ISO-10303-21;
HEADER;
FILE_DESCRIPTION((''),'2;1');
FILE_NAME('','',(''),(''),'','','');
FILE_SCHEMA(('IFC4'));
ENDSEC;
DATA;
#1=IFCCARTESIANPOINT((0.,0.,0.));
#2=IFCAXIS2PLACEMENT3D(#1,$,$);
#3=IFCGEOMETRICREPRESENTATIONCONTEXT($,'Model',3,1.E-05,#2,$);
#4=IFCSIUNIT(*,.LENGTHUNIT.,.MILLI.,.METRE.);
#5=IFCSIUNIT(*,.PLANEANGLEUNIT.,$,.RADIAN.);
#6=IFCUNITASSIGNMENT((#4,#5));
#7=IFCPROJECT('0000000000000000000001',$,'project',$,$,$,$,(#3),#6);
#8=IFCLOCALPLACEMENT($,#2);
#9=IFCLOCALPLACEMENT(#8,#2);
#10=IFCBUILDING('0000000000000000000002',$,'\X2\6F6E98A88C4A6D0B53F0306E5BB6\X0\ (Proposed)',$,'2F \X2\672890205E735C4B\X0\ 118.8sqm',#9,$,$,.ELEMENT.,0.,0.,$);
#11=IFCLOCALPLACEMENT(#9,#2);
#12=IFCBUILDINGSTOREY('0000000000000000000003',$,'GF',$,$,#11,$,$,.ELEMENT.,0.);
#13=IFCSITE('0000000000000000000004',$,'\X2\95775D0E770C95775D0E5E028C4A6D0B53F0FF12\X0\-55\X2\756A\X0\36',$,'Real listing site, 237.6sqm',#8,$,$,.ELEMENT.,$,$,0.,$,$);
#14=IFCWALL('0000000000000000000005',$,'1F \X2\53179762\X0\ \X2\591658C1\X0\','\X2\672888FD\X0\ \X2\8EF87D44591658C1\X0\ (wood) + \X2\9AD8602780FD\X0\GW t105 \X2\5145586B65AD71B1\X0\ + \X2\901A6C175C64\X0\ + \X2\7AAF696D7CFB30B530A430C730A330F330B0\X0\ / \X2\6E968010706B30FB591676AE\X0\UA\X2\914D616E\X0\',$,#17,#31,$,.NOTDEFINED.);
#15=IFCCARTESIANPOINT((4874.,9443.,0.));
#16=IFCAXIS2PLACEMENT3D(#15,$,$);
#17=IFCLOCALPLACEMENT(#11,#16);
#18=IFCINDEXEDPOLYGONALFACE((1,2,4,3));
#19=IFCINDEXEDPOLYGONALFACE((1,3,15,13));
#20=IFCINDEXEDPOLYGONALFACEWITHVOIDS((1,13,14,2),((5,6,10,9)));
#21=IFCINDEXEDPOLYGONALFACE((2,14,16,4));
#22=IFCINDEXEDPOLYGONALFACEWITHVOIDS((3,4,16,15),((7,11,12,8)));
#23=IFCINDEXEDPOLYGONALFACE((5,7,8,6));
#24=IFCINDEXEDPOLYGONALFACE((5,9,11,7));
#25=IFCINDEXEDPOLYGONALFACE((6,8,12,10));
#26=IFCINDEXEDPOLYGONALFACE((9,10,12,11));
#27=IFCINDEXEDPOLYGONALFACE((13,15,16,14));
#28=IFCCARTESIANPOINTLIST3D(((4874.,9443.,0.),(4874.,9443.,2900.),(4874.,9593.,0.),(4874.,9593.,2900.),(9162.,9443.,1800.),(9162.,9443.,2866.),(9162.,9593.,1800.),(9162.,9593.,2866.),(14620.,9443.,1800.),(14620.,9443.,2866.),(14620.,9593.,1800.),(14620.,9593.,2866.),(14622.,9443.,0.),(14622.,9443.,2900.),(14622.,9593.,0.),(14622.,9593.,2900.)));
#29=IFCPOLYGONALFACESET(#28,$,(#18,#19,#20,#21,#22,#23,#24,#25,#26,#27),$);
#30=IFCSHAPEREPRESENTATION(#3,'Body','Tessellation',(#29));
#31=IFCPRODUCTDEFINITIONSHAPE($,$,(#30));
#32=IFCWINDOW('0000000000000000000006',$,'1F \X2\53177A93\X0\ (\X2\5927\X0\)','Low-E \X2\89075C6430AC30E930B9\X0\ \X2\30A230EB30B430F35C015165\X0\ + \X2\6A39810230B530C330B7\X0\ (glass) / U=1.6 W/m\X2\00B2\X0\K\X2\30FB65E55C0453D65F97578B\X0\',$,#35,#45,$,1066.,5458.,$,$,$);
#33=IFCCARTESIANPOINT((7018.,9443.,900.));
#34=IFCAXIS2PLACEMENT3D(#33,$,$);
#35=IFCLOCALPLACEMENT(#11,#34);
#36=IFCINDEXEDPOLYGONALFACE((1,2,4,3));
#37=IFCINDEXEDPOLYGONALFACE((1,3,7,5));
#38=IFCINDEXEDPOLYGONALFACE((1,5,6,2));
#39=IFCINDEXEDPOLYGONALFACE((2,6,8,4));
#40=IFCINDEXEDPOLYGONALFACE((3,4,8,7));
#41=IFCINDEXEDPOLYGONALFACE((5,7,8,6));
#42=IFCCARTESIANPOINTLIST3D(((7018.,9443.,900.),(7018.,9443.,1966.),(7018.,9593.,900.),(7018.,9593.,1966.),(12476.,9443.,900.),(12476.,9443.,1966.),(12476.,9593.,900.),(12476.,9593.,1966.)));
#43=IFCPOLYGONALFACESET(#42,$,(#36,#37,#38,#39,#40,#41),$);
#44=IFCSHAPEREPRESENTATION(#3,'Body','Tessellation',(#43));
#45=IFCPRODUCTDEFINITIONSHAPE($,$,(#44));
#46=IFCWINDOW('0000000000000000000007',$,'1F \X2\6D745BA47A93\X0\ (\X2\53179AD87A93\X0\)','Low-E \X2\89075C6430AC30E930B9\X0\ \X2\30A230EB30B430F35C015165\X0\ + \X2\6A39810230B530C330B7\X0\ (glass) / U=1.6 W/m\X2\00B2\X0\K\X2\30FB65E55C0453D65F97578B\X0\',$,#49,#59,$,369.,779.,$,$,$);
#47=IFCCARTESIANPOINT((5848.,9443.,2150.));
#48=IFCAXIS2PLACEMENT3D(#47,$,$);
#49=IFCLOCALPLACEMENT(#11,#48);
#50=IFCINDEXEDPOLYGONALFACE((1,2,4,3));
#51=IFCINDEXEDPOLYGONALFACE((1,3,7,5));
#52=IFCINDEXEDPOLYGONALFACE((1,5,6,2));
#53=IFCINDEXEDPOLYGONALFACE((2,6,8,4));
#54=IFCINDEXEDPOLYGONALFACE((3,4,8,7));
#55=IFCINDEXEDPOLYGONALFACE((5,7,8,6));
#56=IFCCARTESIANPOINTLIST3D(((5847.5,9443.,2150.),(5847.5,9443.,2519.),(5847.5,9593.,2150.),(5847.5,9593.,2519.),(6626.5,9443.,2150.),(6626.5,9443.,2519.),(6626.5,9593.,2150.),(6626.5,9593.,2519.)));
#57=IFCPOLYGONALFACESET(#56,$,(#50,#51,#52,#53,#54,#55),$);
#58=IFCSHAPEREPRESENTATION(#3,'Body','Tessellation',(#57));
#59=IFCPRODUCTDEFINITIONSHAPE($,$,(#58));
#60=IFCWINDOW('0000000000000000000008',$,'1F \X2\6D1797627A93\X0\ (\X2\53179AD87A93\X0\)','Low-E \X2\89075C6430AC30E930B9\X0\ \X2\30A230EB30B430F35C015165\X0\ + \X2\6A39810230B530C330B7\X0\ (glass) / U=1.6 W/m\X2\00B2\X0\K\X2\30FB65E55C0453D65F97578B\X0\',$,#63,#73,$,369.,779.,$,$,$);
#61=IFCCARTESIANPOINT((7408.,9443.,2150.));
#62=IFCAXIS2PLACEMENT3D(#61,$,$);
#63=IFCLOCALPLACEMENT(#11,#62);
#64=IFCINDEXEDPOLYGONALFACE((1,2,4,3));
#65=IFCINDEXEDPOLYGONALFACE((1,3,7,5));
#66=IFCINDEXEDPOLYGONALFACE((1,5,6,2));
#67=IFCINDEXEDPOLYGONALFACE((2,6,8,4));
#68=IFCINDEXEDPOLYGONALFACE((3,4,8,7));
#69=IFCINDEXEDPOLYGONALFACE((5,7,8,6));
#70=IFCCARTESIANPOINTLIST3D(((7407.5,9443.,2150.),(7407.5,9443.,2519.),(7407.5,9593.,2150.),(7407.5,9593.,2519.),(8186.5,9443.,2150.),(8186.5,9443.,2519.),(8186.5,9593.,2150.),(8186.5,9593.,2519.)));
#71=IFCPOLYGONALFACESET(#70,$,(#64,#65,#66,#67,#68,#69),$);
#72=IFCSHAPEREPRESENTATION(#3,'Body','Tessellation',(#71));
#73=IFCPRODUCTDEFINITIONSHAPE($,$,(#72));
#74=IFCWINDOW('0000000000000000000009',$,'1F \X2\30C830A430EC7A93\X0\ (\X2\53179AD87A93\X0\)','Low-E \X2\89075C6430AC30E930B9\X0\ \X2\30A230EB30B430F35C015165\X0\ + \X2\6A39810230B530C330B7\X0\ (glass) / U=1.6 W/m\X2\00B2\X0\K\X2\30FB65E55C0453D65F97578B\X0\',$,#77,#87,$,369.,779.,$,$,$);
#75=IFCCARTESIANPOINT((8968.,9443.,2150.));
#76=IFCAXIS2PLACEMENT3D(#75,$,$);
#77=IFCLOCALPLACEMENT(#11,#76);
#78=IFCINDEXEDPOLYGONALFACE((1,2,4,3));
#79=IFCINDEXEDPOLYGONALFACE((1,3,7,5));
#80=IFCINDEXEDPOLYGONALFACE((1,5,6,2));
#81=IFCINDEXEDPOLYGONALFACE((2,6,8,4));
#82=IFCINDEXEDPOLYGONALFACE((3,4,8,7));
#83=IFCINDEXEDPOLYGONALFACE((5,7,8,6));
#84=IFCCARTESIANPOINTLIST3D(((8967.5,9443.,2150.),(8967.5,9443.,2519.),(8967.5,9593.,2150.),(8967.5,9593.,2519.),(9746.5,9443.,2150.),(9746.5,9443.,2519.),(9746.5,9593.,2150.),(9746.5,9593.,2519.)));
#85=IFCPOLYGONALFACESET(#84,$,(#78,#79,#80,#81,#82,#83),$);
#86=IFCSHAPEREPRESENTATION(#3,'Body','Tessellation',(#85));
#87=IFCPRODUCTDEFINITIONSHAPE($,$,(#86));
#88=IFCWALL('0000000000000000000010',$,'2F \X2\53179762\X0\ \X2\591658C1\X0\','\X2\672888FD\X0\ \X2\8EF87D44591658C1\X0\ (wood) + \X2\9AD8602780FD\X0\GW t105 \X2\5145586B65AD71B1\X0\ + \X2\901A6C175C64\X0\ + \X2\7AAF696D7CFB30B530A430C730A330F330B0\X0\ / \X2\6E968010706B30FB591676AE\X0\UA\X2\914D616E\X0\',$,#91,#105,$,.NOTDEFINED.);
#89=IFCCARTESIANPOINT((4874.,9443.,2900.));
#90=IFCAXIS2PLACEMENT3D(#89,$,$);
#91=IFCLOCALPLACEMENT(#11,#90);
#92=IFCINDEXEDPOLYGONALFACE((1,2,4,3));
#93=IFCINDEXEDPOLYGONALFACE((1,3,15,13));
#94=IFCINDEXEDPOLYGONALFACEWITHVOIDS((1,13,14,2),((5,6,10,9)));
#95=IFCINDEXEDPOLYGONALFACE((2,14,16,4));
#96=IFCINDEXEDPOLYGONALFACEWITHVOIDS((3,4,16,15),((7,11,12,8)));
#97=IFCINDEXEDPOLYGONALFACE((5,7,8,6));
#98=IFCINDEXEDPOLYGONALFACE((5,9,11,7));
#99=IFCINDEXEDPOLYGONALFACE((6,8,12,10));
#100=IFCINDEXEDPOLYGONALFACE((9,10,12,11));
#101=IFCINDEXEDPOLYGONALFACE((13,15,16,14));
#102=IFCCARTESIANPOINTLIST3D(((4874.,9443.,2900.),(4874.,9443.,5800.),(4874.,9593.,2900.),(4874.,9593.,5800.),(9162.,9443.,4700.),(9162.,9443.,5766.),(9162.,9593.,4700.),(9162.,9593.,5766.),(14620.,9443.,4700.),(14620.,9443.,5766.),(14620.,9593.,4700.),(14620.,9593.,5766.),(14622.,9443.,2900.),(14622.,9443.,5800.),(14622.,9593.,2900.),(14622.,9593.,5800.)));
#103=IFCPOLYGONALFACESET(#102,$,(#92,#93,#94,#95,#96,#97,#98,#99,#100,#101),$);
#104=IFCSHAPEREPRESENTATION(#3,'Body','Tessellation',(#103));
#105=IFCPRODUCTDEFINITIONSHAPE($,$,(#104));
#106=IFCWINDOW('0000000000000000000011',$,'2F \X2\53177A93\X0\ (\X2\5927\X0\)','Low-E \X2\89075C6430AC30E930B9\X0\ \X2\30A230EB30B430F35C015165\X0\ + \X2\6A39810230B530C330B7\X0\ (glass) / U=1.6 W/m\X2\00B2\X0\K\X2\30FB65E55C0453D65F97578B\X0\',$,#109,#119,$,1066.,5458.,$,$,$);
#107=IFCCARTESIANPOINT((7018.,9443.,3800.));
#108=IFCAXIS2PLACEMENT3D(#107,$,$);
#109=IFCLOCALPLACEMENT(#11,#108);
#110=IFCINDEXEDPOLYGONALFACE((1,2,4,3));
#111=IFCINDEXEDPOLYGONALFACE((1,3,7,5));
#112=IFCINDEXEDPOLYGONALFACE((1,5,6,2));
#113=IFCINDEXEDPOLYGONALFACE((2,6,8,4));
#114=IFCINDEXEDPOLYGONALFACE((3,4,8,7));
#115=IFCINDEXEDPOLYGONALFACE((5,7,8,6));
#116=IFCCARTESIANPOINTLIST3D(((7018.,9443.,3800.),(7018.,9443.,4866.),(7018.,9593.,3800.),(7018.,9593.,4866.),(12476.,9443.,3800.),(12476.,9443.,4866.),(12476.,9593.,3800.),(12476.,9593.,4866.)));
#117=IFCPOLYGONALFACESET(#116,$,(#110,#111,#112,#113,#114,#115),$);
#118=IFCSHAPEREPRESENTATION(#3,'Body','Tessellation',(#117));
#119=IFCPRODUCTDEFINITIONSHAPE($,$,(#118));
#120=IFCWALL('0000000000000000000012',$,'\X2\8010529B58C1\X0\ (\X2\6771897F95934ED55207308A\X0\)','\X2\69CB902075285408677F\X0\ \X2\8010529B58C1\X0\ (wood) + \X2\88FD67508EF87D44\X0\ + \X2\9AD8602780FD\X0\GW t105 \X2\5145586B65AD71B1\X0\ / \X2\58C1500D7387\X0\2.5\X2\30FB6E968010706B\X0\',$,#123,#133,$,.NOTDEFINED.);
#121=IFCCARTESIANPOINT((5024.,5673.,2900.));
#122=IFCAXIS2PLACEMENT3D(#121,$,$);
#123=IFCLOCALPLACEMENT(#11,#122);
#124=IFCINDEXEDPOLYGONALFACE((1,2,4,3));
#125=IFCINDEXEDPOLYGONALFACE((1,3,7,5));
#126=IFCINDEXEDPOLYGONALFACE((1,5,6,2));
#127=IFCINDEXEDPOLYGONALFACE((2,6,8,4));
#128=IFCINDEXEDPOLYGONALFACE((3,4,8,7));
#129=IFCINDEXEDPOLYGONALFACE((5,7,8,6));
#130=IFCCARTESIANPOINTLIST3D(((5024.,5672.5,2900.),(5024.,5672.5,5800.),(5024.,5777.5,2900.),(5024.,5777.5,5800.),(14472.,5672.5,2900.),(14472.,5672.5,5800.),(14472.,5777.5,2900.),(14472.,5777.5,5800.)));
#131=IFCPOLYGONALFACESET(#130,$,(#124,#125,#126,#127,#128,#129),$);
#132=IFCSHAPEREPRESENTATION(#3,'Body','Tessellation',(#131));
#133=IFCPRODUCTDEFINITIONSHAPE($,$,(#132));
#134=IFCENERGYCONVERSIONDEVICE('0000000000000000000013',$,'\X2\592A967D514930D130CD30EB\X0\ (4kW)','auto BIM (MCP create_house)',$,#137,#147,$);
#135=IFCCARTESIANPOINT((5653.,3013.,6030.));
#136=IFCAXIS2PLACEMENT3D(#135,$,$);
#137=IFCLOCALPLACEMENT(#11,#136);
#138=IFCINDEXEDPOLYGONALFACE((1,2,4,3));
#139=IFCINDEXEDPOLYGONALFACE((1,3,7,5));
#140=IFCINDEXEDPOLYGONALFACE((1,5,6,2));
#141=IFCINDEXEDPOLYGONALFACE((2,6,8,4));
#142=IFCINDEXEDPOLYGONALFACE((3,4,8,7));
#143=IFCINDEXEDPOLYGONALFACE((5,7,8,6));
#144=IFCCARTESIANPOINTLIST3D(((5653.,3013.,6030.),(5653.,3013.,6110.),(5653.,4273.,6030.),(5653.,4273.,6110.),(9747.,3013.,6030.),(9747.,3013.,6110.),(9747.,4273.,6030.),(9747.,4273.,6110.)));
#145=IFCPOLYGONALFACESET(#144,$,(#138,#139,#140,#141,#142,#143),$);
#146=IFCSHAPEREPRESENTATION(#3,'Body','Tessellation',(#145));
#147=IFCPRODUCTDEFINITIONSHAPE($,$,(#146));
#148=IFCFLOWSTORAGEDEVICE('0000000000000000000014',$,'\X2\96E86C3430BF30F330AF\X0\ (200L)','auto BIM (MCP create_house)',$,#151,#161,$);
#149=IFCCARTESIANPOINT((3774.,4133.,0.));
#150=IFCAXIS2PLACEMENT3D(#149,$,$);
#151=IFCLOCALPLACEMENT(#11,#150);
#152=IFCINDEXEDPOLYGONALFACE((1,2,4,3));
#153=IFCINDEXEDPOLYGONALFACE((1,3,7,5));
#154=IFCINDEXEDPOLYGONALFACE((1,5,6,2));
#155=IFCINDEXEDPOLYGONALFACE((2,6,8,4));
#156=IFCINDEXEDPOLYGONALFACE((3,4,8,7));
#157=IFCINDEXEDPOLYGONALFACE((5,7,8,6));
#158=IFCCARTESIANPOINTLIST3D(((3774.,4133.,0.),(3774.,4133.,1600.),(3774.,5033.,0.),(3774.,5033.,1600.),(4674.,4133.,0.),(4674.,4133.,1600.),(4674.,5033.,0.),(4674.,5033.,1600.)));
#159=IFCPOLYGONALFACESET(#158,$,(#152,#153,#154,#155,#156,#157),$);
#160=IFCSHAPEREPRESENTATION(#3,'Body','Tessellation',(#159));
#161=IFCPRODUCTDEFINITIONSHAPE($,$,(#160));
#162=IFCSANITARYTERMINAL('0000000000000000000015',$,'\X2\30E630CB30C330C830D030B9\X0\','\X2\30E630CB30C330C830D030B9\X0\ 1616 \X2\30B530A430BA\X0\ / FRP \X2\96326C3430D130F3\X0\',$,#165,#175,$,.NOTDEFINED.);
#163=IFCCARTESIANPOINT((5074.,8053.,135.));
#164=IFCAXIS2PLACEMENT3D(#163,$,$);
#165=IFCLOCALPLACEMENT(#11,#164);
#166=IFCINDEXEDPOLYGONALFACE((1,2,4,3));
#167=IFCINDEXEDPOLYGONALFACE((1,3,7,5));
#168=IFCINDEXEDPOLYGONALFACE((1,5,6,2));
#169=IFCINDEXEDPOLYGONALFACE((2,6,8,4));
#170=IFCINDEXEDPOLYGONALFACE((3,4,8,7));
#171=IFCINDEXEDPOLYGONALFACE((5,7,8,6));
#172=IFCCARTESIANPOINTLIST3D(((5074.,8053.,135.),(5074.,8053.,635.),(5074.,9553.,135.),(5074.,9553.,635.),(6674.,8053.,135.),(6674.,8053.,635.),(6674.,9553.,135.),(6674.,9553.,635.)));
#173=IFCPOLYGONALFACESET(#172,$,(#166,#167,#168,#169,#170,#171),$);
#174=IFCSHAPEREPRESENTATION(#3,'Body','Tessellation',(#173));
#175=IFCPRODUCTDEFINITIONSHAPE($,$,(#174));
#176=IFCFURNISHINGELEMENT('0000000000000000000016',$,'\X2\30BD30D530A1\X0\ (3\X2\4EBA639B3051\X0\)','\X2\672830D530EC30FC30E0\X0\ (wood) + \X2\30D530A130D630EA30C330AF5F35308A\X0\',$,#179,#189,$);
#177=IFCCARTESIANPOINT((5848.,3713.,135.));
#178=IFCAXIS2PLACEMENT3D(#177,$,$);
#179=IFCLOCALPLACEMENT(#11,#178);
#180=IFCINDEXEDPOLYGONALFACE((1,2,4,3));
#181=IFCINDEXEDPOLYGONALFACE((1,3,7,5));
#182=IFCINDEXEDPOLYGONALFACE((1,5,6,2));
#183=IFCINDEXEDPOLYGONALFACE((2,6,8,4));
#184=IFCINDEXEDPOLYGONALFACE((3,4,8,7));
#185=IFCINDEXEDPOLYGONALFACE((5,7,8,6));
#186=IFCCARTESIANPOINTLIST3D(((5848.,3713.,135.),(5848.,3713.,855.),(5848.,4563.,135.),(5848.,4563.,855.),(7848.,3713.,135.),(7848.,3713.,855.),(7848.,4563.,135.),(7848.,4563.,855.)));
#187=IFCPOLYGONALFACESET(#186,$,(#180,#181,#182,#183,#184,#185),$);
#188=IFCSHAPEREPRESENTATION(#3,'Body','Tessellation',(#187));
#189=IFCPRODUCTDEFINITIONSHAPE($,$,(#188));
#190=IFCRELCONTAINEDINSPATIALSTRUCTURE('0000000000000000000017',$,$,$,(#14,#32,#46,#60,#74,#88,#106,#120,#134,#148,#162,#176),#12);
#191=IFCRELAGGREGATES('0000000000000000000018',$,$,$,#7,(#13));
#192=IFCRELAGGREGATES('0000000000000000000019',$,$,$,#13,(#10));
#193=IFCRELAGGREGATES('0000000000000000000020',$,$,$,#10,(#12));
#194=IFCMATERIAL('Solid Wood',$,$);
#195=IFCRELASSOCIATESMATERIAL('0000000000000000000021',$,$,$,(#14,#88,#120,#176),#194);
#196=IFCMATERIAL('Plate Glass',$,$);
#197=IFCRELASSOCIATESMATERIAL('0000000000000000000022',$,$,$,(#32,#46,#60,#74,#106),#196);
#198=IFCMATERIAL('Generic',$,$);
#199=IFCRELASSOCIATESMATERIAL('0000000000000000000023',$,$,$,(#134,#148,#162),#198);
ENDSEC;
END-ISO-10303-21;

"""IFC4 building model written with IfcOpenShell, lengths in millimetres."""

from ifc_helpers import new_model, si_unit, frame, frame_2d, origin, place, context, project, spatial, rectangle, extrude, material, element, fill, save


model = new_model("IFC4")

# Units and contexts
model_context = context("Model", 3, precision=1e-05, world=origin())
ifc_project = project(units=[si_unit("LENGTHUNIT", "METRE", prefix="MILLI"), si_unit("PLANEANGLEUNIT", "RADIAN")], contexts=[model_context])

# Site, building, storey
site_placement = place(None, origin())
site = spatial("IfcSite", under=ifc_project, at=site_placement, Name="長崎県長崎市豊洋台２-55番36", ObjectType="Real listing site, 237.6sqm", CompositionType="ELEMENT", RefElevation=0.0)
building_placement = place(site_placement, origin())
building = spatial("IfcBuilding", under=site, at=building_placement, Name="潮風豊洋台の家 (Proposed)", ObjectType="2F 木造平屋 118.8sqm", CompositionType="ELEMENT", ElevationOfRefHeight=0.0, ElevationOfTerrain=0.0)
storey_placement = place(building_placement, origin())
storey = spatial("IfcBuildingStorey", under=building, at=storey_placement, Name="GF", CompositionType="ELEMENT", Elevation=0.0)

# Wall, openings, windows
ifc_material_1 = material(Name="Solid Wood")
wall_1_placement = place(storey_placement, frame((4874.0, 9443.0, 0.0)))
wall_1 = element("IfcWall", 1, at=wall_1_placement, inside=storey, material=ifc_material_1, Name="1F 北面 外壁", Description="木製 軸組外壁 (wood) + 高性能GW t105 充填断熱 + 通気層 + 窯業系サイディング / 準耐火・外皮UA配慮", PredefinedType="NOTDEFINED", context=model_context, shape_type="SweptSolid", body=[
    extrude(rectangle(XDim=9748.0, YDim=150.0, at=frame_2d((4874.0, 75.0))), frame((4874.0, 9443.0, 0.0)), (0.0, 0.0, 1.0), 2900.0),
])
opening_1_placement = place(storey_placement, frame((7018.0, 9443.0, 900.0)))
opening_1 = element("IfcOpeningElement", 2, at=opening_1_placement, cuts=wall_1, PredefinedType="NOTDEFINED", context=model_context, shape_type="SweptSolid", body=[
    extrude(rectangle(XDim=5458.0, YDim=150.0, at=frame_2d((2729.0, 75.0))), frame((7018.0, 9443.0, 900.0)), (0.0, 0.0, 1.0), 1066.0),
])
opening_2_placement = place(storey_placement, frame((5848.0, 9443.0, 2150.0)))
opening_2 = element("IfcOpeningElement", 3, at=opening_2_placement, cuts=wall_1, PredefinedType="NOTDEFINED", context=model_context, shape_type="SweptSolid", body=[
    extrude(rectangle(XDim=779.0, YDim=150.0, at=frame_2d((389.0, 75.0))), frame((5848.0, 9443.0, 2150.0)), (0.0, 0.0, 1.0), 369.0),
])
opening_3_placement = place(storey_placement, frame((7408.0, 9443.0, 2150.0)))
opening_3 = element("IfcOpeningElement", 4, at=opening_3_placement, cuts=wall_1, PredefinedType="NOTDEFINED", context=model_context, shape_type="SweptSolid", body=[
    extrude(rectangle(XDim=779.0, YDim=150.0, at=frame_2d((389.0, 75.0))), frame((7408.0, 9443.0, 2150.0)), (0.0, 0.0, 1.0), 369.0),
])
opening_4_placement = place(storey_placement, frame((8968.0, 9443.0, 2150.0)))
opening_4 = element("IfcOpeningElement", 5, at=opening_4_placement, cuts=wall_1, PredefinedType="NOTDEFINED", context=model_context, shape_type="SweptSolid", body=[
    extrude(rectangle(XDim=779.0, YDim=150.0, at=frame_2d((389.0, 75.0))), frame((8968.0, 9443.0, 2150.0)), (0.0, 0.0, 1.0), 369.0),
])
ifc_material_2 = material(Name="Plate Glass")
window_1_placement = place(storey_placement, frame((7018.0, 9443.0, 900.0)))
window_1 = element("IfcWindow", 6, at=window_1_placement, inside=storey, material=ifc_material_2, Name="1F 北窓 (大)", Description="Low-E 複層ガラス アルゴン封入 + 樹脂サッシ (glass) / U=1.6 W/m²K・日射取得型", OverallHeight=1066.0, OverallWidth=5458.0, context=model_context, shape_type="SweptSolid", body=[
    extrude(rectangle(XDim=5458.0, YDim=150.0, at=frame_2d((2729.0, 75.0))), frame((7018.0, 9443.0, 900.0)), (0.0, 0.0, 1.0), 1066.0),
])
fill(opening_1, window_1)
window_2_placement = place(storey_placement, frame((5848.0, 9443.0, 2150.0)))
window_2 = element("IfcWindow", 7, at=window_2_placement, inside=storey, material=ifc_material_2, Name="1F 浴室窓 (北高窓)", Description="Low-E 複層ガラス アルゴン封入 + 樹脂サッシ (glass) / U=1.6 W/m²K・日射取得型", OverallHeight=369.0, OverallWidth=779.0, context=model_context, shape_type="SweptSolid", body=[
    extrude(rectangle(XDim=779.0, YDim=150.0, at=frame_2d((389.0, 75.0))), frame((5848.0, 9443.0, 2150.0)), (0.0, 0.0, 1.0), 369.0),
])
fill(opening_2, window_2)
window_3_placement = place(storey_placement, frame((7408.0, 9443.0, 2150.0)))
window_3 = element("IfcWindow", 8, at=window_3_placement, inside=storey, material=ifc_material_2, Name="1F 洗面窓 (北高窓)", Description="Low-E 複層ガラス アルゴン封入 + 樹脂サッシ (glass) / U=1.6 W/m²K・日射取得型", OverallHeight=369.0, OverallWidth=779.0, context=model_context, shape_type="SweptSolid", body=[
    extrude(rectangle(XDim=779.0, YDim=150.0, at=frame_2d((389.0, 75.0))), frame((7408.0, 9443.0, 2150.0)), (0.0, 0.0, 1.0), 369.0),
])
fill(opening_3, window_3)
window_4_placement = place(storey_placement, frame((8968.0, 9443.0, 2150.0)))
window_4 = element("IfcWindow", 9, at=window_4_placement, inside=storey, material=ifc_material_2, Name="1F トイレ窓 (北高窓)", Description="Low-E 複層ガラス アルゴン封入 + 樹脂サッシ (glass) / U=1.6 W/m²K・日射取得型", OverallHeight=369.0, OverallWidth=779.0, context=model_context, shape_type="SweptSolid", body=[
    extrude(rectangle(XDim=779.0, YDim=150.0, at=frame_2d((389.0, 75.0))), frame((8968.0, 9443.0, 2150.0)), (0.0, 0.0, 1.0), 369.0),
])
fill(opening_4, window_4)

# Wall, opening, window
wall_2_placement = place(storey_placement, frame((4874.0, 9443.0, 2900.0)))
wall_2 = element("IfcWall", 10, at=wall_2_placement, inside=storey, material=ifc_material_1, Name="2F 北面 外壁", Description="木製 軸組外壁 (wood) + 高性能GW t105 充填断熱 + 通気層 + 窯業系サイディング / 準耐火・外皮UA配慮", PredefinedType="NOTDEFINED", context=model_context, shape_type="SweptSolid", body=[
    extrude(rectangle(XDim=9748.0, YDim=150.0, at=frame_2d((4874.0, 75.0))), frame((4874.0, 9443.0, 2900.0)), (0.0, 0.0, 1.0), 2900.0),
])
opening_5_placement = place(storey_placement, frame((7018.0, 9443.0, 3800.0)))
opening_5 = element("IfcOpeningElement", 11, at=opening_5_placement, cuts=wall_2, PredefinedType="NOTDEFINED", context=model_context, shape_type="SweptSolid", body=[
    extrude(rectangle(XDim=5458.0, YDim=150.0, at=frame_2d((2729.0, 75.0))), frame((7018.0, 9443.0, 3800.0)), (0.0, 0.0, 1.0), 1066.0),
])
window_5_placement = place(storey_placement, frame((7018.0, 9443.0, 3800.0)))
window_5 = element("IfcWindow", 12, at=window_5_placement, inside=storey, material=ifc_material_2, Name="2F 北窓 (大)", Description="Low-E 複層ガラス アルゴン封入 + 樹脂サッシ (glass) / U=1.6 W/m²K・日射取得型", OverallHeight=1066.0, OverallWidth=5458.0, context=model_context, shape_type="SweptSolid", body=[
    extrude(rectangle(XDim=5458.0, YDim=150.0, at=frame_2d((2729.0, 75.0))), frame((7018.0, 9443.0, 3800.0)), (0.0, 0.0, 1.0), 1066.0),
])
fill(opening_5, window_5)

# Wall
wall_3_placement = place(storey_placement, frame((5024.0, 5673.0, 2900.0)))
element("IfcWall", 13, at=wall_3_placement, inside=storey, material=ifc_material_1, Name="耐力壁 (東西間仕切り)", Description="構造用合板 耐力壁 (wood) + 製材軸組 + 高性能GW t105 充填断熱 / 壁倍率2.5・準耐火", PredefinedType="NOTDEFINED", context=model_context, shape_type="SweptSolid", body=[
    extrude(rectangle(XDim=9448.0, YDim=105.0, at=frame_2d((4724.0, 52.0))), frame((5024.0, 5673.0, 2900.0)), (0.0, 0.0, 1.0), 2900.0),
])

# Energy conversion device
ifc_material_3 = material(Name="Generic")
energy_conversion_device_placement = place(storey_placement, frame((5653.0, 3013.0, 6030.0)))
element("IfcEnergyConversionDevice", 14, at=energy_conversion_device_placement, inside=storey, material=ifc_material_3, Name="太陽光パネル (4kW)", Description="auto BIM (MCP create_house)", context=model_context, shape_type="SweptSolid", body=[
    extrude(rectangle(XDim=4094.0, YDim=1260.0, at=frame_2d((2047.0, 630.0))), frame((5653.0, 3013.0, 6030.0)), (0.0, 0.0, 1.0), 80.0),
])

# Flow storage device
flow_storage_device_placement = place(storey_placement, frame((3774.0, 4133.0, 0.0)))
element("IfcFlowStorageDevice", 15, at=flow_storage_device_placement, inside=storey, material=ifc_material_3, Name="雨水タンク (200L)", Description="auto BIM (MCP create_house)", context=model_context, shape_type="SweptSolid", body=[
    extrude(rectangle(XDim=900.0, YDim=900.0, at=frame_2d((450.0, 450.0))), frame((3774.0, 4133.0, 0.0)), (0.0, 0.0, 1.0), 1600.0),
])

# Sanitary terminal
sanitary_terminal_placement = place(storey_placement, frame((5074.0, 8053.0, 135.0)))
element("IfcSanitaryTerminal", 16, at=sanitary_terminal_placement, inside=storey, material=ifc_material_3, Name="ユニットバス", Description="ユニットバス 1616 サイズ / FRP 防水パン", PredefinedType="NOTDEFINED", context=model_context, shape_type="SweptSolid", body=[
    extrude(rectangle(XDim=1600.0, YDim=1500.0, at=frame_2d((800.0, 750.0))), frame((5074.0, 8053.0, 135.0)), (0.0, 0.0, 1.0), 500.0),
])

# Furnishing element
furnishing_1_placement = place(storey_placement, frame((5848.0, 3713.0, 135.0)))
element("IfcFurnishingElement", 17, at=furnishing_1_placement, inside=storey, material=ifc_material_1, Name="ソファ (3人掛け)", Description="木フレーム (wood) + ファブリック張り", context=model_context, shape_type="SweptSolid", body=[
    extrude(rectangle(XDim=2000.0, YDim=850.0, at=frame_2d((1000.0, 425.0))), frame((5848.0, 3713.0, 135.0)), (0.0, 0.0, 1.0), 720.0),
])

save(model, "model.ifc")
